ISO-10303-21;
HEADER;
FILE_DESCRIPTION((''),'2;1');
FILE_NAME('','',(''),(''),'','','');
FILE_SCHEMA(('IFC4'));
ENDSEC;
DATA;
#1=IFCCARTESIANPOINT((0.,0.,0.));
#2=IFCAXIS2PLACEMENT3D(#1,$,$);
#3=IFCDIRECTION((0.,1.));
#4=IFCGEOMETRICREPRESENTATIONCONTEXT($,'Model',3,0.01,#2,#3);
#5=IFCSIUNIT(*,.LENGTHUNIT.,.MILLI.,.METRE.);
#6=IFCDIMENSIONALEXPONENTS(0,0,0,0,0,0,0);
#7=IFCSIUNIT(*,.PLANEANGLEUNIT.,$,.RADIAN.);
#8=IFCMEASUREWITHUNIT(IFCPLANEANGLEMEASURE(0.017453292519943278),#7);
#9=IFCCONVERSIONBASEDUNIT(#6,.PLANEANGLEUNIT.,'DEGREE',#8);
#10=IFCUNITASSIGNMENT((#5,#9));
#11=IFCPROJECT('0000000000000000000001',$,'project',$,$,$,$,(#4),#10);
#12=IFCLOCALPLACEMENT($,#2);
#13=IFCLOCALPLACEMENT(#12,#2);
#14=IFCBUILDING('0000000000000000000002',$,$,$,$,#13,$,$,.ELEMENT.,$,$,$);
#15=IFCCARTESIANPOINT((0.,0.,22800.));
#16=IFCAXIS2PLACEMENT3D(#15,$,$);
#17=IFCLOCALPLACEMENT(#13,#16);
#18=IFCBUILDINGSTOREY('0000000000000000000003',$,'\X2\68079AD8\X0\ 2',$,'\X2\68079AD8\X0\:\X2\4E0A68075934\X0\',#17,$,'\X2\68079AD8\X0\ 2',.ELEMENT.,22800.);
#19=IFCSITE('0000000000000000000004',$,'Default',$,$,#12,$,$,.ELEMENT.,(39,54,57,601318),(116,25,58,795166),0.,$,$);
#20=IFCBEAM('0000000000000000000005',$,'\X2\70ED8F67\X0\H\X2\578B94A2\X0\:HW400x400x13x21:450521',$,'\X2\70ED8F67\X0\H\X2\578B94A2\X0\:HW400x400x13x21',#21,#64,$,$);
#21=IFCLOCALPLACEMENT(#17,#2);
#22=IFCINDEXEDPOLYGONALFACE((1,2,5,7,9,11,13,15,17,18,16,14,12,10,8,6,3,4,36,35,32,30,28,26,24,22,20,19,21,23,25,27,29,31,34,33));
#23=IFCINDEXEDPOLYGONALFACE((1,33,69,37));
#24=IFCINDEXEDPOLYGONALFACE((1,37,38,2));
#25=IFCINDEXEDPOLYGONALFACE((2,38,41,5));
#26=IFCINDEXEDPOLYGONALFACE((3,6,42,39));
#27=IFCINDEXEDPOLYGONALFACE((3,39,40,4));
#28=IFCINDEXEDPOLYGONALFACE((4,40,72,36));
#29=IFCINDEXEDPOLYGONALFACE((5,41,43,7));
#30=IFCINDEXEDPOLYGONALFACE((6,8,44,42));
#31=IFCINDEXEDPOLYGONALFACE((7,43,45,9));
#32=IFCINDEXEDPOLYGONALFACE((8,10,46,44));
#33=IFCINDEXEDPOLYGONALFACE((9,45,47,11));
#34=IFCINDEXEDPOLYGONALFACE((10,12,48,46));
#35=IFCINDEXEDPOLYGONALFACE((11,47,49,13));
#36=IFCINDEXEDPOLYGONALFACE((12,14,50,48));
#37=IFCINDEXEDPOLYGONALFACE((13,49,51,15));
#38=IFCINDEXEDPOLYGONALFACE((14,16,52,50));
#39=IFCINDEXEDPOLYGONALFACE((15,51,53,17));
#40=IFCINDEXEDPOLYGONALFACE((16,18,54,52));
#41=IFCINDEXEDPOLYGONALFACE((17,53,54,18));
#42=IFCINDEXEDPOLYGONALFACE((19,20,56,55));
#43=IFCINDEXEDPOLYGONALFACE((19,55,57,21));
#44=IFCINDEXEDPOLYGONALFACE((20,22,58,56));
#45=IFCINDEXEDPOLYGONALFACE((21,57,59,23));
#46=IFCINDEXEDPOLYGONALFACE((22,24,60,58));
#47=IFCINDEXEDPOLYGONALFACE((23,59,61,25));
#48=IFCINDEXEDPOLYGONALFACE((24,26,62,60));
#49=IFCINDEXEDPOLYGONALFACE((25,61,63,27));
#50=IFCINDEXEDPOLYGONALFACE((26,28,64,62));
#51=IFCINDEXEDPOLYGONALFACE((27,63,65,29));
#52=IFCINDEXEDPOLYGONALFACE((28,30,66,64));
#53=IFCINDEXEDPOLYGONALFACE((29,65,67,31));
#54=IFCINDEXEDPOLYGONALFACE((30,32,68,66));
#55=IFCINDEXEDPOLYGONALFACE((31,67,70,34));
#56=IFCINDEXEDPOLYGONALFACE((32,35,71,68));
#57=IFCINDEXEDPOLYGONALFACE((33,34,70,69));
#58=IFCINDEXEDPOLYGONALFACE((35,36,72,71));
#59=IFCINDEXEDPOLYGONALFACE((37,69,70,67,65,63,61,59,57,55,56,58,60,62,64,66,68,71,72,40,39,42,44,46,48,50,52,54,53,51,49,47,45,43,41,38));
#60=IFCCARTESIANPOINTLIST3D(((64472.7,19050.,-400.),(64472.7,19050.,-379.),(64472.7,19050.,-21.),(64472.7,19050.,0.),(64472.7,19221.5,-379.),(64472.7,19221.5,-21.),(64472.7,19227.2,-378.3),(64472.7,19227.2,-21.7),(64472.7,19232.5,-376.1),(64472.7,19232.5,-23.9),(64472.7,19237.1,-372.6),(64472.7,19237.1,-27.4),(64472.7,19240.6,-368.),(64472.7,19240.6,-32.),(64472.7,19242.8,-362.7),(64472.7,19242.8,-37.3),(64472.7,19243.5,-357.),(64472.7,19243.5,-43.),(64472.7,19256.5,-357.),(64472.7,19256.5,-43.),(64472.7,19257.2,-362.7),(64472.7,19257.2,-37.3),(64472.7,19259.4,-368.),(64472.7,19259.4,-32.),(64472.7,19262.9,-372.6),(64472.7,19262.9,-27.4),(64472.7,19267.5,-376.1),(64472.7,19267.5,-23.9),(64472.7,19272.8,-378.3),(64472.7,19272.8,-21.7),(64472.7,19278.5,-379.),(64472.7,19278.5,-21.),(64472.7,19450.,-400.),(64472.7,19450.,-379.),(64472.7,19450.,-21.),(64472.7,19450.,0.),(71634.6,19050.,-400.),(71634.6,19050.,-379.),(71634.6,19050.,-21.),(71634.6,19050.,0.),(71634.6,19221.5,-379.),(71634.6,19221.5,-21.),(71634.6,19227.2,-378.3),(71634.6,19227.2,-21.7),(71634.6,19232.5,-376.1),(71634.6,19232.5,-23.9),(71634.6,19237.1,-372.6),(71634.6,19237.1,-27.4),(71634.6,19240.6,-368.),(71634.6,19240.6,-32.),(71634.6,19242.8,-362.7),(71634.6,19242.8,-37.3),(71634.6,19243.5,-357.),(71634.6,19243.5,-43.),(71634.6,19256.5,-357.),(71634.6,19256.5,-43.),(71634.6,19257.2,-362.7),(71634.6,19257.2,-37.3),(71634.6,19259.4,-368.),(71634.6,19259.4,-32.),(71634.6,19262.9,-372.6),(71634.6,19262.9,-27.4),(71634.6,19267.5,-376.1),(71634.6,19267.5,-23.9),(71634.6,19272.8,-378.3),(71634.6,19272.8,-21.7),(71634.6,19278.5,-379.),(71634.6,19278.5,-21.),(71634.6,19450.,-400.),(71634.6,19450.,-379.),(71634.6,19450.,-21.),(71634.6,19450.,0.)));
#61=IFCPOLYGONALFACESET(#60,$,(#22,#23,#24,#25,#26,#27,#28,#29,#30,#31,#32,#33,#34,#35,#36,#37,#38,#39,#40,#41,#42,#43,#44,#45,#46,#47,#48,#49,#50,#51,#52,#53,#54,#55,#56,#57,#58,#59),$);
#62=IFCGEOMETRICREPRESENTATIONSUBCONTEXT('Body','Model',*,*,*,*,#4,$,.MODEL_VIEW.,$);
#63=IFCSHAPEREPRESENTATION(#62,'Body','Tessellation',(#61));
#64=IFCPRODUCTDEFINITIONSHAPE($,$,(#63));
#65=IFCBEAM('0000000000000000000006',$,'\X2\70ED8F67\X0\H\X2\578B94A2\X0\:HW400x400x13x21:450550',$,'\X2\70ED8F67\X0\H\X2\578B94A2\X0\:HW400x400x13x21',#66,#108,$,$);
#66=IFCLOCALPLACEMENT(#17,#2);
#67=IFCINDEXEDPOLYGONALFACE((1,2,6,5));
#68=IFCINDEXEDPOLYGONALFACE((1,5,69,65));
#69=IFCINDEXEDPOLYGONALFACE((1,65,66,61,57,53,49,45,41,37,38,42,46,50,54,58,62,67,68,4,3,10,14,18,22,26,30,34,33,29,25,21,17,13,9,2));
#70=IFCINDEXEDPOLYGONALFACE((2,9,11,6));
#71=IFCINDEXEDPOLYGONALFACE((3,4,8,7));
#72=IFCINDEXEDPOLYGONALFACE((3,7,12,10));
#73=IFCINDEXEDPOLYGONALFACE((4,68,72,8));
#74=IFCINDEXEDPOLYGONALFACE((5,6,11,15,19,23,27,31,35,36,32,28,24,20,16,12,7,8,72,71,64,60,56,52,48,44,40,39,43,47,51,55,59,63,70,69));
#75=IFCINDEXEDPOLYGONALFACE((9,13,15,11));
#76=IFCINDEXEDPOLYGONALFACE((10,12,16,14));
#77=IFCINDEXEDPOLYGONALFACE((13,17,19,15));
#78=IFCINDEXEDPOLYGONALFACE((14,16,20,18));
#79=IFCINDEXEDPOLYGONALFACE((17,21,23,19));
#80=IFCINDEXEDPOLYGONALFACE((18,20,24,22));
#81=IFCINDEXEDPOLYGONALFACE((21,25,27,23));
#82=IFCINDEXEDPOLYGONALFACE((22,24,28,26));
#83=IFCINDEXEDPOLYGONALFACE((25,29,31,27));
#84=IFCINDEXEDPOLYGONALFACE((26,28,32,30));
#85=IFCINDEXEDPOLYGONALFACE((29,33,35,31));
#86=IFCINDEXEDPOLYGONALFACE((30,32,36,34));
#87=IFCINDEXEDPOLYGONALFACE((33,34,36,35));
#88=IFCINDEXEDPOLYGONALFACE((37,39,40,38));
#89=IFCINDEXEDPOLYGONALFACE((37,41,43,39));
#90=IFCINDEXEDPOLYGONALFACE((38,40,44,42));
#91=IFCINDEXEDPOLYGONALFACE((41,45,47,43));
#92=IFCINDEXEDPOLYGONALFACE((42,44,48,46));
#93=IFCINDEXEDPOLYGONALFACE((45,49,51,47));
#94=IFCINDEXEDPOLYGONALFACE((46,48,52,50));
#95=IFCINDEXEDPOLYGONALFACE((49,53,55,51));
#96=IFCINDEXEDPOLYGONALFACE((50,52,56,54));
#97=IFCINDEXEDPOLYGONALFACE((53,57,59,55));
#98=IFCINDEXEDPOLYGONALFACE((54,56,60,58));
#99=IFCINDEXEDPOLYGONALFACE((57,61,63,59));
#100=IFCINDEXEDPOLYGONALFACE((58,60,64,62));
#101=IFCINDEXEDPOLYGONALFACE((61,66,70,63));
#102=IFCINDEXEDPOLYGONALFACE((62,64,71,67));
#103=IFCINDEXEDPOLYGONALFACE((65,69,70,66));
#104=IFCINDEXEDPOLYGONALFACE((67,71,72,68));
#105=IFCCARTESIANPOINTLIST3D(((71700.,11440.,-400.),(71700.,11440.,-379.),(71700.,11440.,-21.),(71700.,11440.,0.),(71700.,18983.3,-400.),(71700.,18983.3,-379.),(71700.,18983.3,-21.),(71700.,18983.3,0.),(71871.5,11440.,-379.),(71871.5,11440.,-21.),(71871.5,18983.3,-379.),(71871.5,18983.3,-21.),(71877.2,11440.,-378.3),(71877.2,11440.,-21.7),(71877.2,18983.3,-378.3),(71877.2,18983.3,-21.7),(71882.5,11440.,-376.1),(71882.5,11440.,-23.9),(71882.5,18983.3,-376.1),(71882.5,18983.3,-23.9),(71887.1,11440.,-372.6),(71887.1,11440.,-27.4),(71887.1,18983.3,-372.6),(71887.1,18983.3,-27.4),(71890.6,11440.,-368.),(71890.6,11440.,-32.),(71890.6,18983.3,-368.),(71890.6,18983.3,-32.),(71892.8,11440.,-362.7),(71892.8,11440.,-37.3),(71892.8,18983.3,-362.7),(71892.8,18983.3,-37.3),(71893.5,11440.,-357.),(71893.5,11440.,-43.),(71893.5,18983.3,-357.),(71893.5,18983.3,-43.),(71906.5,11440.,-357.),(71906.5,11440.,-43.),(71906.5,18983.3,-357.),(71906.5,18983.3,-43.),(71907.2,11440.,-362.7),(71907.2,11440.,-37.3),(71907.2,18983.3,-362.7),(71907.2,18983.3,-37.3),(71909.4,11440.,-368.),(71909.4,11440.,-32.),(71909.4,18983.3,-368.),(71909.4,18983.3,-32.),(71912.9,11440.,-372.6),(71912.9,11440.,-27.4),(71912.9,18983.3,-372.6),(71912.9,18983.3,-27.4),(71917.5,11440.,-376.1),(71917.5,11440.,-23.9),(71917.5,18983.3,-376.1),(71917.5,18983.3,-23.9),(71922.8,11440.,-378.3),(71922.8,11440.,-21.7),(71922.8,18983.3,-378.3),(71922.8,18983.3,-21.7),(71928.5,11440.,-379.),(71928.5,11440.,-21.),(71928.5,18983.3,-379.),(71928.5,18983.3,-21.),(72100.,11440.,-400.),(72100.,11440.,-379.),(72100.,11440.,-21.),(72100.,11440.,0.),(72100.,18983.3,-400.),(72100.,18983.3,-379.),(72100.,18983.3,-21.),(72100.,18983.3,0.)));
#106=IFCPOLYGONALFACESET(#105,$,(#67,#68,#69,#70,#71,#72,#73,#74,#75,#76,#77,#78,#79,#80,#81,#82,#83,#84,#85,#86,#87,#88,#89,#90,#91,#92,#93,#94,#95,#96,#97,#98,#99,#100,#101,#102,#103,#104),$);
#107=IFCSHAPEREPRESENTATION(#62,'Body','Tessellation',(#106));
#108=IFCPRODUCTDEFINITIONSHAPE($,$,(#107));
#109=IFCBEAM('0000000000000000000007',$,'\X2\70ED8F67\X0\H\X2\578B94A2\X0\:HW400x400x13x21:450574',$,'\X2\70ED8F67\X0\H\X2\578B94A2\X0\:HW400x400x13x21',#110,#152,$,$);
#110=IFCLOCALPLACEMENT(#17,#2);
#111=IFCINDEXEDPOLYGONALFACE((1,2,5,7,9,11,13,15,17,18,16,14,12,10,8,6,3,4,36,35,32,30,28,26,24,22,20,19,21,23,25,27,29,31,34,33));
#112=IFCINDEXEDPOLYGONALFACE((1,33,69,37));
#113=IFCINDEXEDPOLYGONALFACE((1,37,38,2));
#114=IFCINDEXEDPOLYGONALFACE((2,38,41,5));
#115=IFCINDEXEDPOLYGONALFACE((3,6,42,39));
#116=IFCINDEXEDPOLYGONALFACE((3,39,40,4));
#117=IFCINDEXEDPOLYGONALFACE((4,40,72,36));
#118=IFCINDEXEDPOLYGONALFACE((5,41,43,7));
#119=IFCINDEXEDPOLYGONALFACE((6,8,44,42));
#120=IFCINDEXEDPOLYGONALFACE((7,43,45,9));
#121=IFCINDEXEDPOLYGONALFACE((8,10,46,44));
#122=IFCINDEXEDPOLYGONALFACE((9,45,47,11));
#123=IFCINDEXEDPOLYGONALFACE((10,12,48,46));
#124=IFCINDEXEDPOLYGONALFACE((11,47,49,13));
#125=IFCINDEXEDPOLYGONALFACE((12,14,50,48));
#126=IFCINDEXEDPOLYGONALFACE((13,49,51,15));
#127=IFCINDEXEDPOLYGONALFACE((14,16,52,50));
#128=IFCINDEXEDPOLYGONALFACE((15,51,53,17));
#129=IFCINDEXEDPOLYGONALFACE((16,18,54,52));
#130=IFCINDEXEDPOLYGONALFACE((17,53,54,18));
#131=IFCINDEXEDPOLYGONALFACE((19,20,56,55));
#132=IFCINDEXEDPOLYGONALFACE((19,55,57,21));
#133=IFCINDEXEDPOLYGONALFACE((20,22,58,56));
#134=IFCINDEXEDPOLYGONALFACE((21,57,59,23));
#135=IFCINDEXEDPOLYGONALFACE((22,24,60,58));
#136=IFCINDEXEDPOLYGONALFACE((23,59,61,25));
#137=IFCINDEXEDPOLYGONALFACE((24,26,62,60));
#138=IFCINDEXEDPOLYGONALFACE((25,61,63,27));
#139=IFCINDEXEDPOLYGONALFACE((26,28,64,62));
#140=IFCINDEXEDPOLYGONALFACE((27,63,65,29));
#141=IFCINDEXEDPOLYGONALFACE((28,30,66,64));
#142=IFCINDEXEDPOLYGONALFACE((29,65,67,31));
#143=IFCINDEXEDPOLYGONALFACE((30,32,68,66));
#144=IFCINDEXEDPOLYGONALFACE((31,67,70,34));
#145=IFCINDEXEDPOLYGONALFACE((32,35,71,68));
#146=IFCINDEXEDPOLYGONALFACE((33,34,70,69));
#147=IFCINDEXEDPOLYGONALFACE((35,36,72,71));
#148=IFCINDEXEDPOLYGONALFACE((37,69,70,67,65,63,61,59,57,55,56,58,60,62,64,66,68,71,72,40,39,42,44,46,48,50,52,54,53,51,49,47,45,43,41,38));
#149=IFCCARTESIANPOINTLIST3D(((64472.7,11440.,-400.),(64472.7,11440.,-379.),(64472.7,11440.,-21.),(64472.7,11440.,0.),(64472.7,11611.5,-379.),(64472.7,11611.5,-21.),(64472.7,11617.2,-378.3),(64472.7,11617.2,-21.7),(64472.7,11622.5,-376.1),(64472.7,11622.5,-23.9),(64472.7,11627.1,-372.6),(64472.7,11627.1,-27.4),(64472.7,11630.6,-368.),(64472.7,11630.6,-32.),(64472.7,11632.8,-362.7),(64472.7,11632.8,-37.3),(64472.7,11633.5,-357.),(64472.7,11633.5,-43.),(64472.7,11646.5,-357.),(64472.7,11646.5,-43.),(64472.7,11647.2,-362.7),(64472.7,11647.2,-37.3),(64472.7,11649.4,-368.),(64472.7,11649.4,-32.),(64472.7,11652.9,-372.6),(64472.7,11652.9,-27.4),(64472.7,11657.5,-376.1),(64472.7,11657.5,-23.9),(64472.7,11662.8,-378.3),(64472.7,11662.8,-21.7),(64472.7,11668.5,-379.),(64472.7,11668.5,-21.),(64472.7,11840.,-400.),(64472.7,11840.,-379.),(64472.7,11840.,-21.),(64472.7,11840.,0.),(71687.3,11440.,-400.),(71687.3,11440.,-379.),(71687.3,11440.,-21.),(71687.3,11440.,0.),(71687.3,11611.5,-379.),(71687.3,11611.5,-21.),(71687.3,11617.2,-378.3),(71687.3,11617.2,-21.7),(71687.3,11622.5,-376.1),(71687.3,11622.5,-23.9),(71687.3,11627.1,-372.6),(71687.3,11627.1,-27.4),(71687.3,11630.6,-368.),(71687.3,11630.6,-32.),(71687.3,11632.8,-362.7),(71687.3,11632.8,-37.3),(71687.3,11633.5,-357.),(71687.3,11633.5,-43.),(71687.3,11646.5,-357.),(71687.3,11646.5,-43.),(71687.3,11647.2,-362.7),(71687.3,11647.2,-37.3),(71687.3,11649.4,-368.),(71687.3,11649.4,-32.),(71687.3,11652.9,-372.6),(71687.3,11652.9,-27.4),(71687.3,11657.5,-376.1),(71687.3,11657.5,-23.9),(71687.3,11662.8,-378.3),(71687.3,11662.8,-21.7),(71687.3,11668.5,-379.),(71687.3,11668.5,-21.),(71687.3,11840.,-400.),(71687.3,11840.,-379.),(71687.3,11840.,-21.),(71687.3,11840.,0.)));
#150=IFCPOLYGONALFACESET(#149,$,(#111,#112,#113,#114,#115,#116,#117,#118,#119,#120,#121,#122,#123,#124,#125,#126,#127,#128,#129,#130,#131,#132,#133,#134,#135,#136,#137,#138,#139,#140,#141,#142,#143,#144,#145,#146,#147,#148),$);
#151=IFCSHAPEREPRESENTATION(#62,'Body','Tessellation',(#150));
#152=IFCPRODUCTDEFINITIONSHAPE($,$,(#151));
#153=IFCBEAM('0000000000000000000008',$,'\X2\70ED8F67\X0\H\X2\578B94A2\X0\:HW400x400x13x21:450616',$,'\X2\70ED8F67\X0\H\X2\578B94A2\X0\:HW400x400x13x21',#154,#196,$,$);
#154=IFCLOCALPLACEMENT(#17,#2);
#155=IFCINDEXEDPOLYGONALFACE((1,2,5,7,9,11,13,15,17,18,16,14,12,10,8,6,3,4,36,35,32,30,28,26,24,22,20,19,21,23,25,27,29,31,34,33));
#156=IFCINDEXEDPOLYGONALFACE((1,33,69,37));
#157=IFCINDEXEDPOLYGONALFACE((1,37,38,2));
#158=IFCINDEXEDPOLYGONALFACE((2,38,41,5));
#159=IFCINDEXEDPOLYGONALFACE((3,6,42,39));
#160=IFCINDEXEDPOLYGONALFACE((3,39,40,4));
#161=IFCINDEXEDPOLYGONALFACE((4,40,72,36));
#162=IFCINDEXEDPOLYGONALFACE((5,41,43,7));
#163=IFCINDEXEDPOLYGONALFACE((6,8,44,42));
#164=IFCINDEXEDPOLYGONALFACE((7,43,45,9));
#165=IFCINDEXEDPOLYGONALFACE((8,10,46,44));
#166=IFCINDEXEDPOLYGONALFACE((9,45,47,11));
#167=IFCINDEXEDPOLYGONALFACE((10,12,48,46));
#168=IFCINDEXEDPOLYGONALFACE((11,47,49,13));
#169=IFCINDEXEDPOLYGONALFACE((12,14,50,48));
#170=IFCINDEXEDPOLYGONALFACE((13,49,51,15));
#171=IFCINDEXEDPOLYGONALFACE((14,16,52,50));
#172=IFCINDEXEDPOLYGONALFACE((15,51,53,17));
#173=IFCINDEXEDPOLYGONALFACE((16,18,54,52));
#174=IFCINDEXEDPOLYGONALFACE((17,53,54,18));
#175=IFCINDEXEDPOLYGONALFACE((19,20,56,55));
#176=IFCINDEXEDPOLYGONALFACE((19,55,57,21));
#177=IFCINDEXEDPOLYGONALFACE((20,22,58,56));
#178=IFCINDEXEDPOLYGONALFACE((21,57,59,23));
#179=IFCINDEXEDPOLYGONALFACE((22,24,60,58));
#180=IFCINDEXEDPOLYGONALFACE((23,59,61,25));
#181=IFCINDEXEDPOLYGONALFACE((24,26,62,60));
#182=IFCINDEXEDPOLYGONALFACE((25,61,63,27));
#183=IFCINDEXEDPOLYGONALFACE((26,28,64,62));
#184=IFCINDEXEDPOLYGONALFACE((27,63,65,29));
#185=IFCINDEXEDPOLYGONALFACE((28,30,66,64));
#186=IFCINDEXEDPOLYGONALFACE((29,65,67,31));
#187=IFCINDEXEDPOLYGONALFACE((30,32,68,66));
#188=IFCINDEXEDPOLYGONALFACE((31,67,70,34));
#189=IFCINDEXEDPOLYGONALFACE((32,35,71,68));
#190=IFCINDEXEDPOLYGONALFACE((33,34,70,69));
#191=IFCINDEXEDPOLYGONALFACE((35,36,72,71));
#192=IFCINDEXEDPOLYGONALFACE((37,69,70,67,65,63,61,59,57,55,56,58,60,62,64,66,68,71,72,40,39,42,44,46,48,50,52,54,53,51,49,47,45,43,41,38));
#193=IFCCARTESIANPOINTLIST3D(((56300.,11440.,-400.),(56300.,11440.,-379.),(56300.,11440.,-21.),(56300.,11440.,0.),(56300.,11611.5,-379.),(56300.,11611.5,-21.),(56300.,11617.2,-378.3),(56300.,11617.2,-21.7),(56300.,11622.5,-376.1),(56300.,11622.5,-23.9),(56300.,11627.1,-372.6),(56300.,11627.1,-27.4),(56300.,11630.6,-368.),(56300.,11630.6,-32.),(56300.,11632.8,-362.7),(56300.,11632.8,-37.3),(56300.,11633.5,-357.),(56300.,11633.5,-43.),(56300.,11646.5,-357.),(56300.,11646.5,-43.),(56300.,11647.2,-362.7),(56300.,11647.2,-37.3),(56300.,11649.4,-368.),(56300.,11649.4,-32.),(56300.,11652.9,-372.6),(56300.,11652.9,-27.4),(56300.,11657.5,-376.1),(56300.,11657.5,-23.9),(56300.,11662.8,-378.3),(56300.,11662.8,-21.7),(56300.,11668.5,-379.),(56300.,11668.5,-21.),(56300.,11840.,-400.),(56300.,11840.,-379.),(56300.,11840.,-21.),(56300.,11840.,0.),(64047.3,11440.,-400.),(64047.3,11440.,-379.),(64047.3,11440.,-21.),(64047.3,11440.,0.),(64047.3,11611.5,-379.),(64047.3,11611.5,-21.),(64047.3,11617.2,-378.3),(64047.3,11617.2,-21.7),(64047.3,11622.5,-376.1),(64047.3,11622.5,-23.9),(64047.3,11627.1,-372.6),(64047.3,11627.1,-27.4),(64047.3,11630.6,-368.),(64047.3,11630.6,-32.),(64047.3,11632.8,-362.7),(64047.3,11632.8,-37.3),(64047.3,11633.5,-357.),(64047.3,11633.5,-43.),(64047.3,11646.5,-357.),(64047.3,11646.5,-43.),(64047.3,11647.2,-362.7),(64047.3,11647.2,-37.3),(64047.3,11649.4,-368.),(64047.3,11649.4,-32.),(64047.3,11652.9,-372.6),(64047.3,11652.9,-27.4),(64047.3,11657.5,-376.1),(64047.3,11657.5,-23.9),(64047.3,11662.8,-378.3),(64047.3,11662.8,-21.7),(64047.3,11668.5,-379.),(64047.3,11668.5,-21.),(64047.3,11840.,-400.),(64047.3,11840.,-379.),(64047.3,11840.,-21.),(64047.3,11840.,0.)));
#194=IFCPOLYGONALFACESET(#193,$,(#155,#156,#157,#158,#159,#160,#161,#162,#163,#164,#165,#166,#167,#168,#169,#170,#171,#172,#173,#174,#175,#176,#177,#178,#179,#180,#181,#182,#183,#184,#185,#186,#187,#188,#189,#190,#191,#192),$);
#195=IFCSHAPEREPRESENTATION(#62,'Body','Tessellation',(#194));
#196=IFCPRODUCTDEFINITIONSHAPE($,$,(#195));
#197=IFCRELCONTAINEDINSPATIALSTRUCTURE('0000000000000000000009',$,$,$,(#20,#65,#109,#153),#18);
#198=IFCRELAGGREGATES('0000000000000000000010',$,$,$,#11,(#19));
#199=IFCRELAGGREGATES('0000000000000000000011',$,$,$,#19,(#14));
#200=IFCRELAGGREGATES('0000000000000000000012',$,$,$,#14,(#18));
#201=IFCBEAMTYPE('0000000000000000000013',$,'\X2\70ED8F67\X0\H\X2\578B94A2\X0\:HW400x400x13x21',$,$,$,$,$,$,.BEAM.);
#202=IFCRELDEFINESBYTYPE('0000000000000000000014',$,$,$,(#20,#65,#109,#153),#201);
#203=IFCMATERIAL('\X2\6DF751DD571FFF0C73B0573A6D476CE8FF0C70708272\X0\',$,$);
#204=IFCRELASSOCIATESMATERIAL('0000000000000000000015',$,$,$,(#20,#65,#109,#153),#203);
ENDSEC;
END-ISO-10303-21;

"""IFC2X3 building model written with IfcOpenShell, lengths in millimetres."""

from ifc_helpers import new_model, entity, si_unit, converted_unit, direction, frame, frame_2d, origin, place, context, subcontext, project, spatial, i_section, extrude, material, type_object, element, save


model = new_model("IFC2X3")

# Units and contexts
model_context = context("Model", 3, precision=0.01, world=origin(), true_north=direction((0.0, 1.0)))
body_context = subcontext(model_context, "Body", "Model", "MODEL_VIEW")
ifc_project = project(units=[si_unit("LENGTHUNIT", "METRE", prefix="MILLI"), converted_unit("PLANEANGLEUNIT", "DEGREE", entity("IfcPlaneAngleMeasure", 0.017453292519943278), si_unit("PLANEANGLEUNIT", "RADIAN"), dimensions=[0, 0, 0, 0, 0, 0, 0])], contexts=[model_context])

# Site, building, storey
site_placement = place(None, origin())
site = spatial("IfcSite", under=ifc_project, at=site_placement, Name="Default", CompositionType="ELEMENT", RefLatitude=(39, 54, 57, 601318), RefLongitude=(116, 25, 58, 795166), RefElevation=0.0)
building_placement = place(site_placement, origin())
building = spatial("IfcBuilding", under=site, at=building_placement, CompositionType="ELEMENT")
storey_placement = place(building_placement, frame((0.0, 0.0, 22800.0)))
storey = spatial("IfcBuildingStorey", under=building, at=storey_placement, Name="标高 2", ObjectType="标高:上标头", LongName="标高 2", CompositionType="ELEMENT", Elevation=22800.0)

# Beams
ifc_material = material(Name="混凝土，现场浇注，灰色")
beam_type = type_object("IfcBeamType", Name="热轧H型钢:HW400x400x13x21", PredefinedType="BEAM")
beam_1_placement = place(storey_placement, frame((71900.0, 19250.0, 0.0), z_axis=(0.0, 0.0, 1.0), x_axis=(-1.0, 0.0, 0.0)))
element("IfcBeam", 1, at=beam_1_placement, inside=storey, type_object=beam_type, material=ifc_material, Name="热轧H型钢:HW400x400x13x21:450521", ObjectType="热轧H型钢:HW400x400x13x21", context=body_context, shape_type="SweptSolid", body=[
    extrude(i_section(OverallWidth=400.0, OverallDepth=400.0, WebThickness=13.0, FlangeThickness=21.0, FilletRadius=22.0, at=frame_2d((0.0, 0.0), x_axis=(0.0, 1.0))), frame((265.4, 0.0, -200.0), z_axis=(1.0, 0.0, 0.0), x_axis=(0.0, 0.0, -1.0)), (0.0, 0.0, 1.0), 7161.9),
])
beam_2_placement = place(storey_placement, frame((71900.0, 19250.0, 0.0), z_axis=(0.0, 0.0, 1.0), x_axis=(0.0, -1.0, 0.0)))
element("IfcBeam", 2, at=beam_2_placement, inside=storey, type_object=beam_type, material=ifc_material, Name="热轧H型钢:HW400x400x13x21:450550", ObjectType="热轧H型钢:HW400x400x13x21", context=body_context, shape_type="SweptSolid", body=[
    extrude(i_section(OverallWidth=400.0, OverallDepth=400.0, WebThickness=13.0, FlangeThickness=21.0, FilletRadius=22.0, at=frame_2d((0.0, 0.0), x_axis=(0.0, 1.0))), frame((266.7, 0.0, -200.0), z_axis=(1.0, 0.0, 0.0), x_axis=(0.0, 0.0, -1.0)), (0.0, 0.0, 1.0), 7543.3),
])
beam_3_placement = place(storey_placement, frame((71900.0, 11640.0, 0.0), z_axis=(0.0, 0.0, 1.0), x_axis=(-1.0, 0.0, 0.0)))
element("IfcBeam", 3, at=beam_3_placement, inside=storey, type_object=beam_type, material=ifc_material, Name="热轧H型钢:HW400x400x13x21:450574", ObjectType="热轧H型钢:HW400x400x13x21", context=body_context, shape_type="SweptSolid", body=[
    extrude(i_section(OverallWidth=400.0, OverallDepth=400.0, WebThickness=13.0, FlangeThickness=21.0, FilletRadius=22.0, at=frame_2d((0.0, 0.0), x_axis=(0.0, 1.0))), frame((212.7, 0.0, -200.0), z_axis=(1.0, 0.0, 0.0), x_axis=(0.0, 0.0, -1.0)), (0.0, 0.0, 1.0), 7214.6),
])
beam_4_placement = place(storey_placement, frame((56300.0, 11640.0, 0.0)))
element("IfcBeam", 4, at=beam_4_placement, inside=storey, type_object=beam_type, material=ifc_material, Name="热轧H型钢:HW400x400x13x21:450616", ObjectType="热轧H型钢:HW400x400x13x21", context=body_context, shape_type="SweptSolid", body=[
    extrude(i_section(OverallWidth=400.0, OverallDepth=400.0, WebThickness=13.0, FlangeThickness=21.0, FilletRadius=22.0, at=frame_2d((0.0, 0.0), x_axis=(0.0, 1.0))), frame((0.0, 0.0, -200.0), z_axis=(1.0, 0.0, 0.0), x_axis=(0.0, 0.0, -1.0)), (0.0, 0.0, 1.0), 7747.3),
])

save(model, "model.ifc")
